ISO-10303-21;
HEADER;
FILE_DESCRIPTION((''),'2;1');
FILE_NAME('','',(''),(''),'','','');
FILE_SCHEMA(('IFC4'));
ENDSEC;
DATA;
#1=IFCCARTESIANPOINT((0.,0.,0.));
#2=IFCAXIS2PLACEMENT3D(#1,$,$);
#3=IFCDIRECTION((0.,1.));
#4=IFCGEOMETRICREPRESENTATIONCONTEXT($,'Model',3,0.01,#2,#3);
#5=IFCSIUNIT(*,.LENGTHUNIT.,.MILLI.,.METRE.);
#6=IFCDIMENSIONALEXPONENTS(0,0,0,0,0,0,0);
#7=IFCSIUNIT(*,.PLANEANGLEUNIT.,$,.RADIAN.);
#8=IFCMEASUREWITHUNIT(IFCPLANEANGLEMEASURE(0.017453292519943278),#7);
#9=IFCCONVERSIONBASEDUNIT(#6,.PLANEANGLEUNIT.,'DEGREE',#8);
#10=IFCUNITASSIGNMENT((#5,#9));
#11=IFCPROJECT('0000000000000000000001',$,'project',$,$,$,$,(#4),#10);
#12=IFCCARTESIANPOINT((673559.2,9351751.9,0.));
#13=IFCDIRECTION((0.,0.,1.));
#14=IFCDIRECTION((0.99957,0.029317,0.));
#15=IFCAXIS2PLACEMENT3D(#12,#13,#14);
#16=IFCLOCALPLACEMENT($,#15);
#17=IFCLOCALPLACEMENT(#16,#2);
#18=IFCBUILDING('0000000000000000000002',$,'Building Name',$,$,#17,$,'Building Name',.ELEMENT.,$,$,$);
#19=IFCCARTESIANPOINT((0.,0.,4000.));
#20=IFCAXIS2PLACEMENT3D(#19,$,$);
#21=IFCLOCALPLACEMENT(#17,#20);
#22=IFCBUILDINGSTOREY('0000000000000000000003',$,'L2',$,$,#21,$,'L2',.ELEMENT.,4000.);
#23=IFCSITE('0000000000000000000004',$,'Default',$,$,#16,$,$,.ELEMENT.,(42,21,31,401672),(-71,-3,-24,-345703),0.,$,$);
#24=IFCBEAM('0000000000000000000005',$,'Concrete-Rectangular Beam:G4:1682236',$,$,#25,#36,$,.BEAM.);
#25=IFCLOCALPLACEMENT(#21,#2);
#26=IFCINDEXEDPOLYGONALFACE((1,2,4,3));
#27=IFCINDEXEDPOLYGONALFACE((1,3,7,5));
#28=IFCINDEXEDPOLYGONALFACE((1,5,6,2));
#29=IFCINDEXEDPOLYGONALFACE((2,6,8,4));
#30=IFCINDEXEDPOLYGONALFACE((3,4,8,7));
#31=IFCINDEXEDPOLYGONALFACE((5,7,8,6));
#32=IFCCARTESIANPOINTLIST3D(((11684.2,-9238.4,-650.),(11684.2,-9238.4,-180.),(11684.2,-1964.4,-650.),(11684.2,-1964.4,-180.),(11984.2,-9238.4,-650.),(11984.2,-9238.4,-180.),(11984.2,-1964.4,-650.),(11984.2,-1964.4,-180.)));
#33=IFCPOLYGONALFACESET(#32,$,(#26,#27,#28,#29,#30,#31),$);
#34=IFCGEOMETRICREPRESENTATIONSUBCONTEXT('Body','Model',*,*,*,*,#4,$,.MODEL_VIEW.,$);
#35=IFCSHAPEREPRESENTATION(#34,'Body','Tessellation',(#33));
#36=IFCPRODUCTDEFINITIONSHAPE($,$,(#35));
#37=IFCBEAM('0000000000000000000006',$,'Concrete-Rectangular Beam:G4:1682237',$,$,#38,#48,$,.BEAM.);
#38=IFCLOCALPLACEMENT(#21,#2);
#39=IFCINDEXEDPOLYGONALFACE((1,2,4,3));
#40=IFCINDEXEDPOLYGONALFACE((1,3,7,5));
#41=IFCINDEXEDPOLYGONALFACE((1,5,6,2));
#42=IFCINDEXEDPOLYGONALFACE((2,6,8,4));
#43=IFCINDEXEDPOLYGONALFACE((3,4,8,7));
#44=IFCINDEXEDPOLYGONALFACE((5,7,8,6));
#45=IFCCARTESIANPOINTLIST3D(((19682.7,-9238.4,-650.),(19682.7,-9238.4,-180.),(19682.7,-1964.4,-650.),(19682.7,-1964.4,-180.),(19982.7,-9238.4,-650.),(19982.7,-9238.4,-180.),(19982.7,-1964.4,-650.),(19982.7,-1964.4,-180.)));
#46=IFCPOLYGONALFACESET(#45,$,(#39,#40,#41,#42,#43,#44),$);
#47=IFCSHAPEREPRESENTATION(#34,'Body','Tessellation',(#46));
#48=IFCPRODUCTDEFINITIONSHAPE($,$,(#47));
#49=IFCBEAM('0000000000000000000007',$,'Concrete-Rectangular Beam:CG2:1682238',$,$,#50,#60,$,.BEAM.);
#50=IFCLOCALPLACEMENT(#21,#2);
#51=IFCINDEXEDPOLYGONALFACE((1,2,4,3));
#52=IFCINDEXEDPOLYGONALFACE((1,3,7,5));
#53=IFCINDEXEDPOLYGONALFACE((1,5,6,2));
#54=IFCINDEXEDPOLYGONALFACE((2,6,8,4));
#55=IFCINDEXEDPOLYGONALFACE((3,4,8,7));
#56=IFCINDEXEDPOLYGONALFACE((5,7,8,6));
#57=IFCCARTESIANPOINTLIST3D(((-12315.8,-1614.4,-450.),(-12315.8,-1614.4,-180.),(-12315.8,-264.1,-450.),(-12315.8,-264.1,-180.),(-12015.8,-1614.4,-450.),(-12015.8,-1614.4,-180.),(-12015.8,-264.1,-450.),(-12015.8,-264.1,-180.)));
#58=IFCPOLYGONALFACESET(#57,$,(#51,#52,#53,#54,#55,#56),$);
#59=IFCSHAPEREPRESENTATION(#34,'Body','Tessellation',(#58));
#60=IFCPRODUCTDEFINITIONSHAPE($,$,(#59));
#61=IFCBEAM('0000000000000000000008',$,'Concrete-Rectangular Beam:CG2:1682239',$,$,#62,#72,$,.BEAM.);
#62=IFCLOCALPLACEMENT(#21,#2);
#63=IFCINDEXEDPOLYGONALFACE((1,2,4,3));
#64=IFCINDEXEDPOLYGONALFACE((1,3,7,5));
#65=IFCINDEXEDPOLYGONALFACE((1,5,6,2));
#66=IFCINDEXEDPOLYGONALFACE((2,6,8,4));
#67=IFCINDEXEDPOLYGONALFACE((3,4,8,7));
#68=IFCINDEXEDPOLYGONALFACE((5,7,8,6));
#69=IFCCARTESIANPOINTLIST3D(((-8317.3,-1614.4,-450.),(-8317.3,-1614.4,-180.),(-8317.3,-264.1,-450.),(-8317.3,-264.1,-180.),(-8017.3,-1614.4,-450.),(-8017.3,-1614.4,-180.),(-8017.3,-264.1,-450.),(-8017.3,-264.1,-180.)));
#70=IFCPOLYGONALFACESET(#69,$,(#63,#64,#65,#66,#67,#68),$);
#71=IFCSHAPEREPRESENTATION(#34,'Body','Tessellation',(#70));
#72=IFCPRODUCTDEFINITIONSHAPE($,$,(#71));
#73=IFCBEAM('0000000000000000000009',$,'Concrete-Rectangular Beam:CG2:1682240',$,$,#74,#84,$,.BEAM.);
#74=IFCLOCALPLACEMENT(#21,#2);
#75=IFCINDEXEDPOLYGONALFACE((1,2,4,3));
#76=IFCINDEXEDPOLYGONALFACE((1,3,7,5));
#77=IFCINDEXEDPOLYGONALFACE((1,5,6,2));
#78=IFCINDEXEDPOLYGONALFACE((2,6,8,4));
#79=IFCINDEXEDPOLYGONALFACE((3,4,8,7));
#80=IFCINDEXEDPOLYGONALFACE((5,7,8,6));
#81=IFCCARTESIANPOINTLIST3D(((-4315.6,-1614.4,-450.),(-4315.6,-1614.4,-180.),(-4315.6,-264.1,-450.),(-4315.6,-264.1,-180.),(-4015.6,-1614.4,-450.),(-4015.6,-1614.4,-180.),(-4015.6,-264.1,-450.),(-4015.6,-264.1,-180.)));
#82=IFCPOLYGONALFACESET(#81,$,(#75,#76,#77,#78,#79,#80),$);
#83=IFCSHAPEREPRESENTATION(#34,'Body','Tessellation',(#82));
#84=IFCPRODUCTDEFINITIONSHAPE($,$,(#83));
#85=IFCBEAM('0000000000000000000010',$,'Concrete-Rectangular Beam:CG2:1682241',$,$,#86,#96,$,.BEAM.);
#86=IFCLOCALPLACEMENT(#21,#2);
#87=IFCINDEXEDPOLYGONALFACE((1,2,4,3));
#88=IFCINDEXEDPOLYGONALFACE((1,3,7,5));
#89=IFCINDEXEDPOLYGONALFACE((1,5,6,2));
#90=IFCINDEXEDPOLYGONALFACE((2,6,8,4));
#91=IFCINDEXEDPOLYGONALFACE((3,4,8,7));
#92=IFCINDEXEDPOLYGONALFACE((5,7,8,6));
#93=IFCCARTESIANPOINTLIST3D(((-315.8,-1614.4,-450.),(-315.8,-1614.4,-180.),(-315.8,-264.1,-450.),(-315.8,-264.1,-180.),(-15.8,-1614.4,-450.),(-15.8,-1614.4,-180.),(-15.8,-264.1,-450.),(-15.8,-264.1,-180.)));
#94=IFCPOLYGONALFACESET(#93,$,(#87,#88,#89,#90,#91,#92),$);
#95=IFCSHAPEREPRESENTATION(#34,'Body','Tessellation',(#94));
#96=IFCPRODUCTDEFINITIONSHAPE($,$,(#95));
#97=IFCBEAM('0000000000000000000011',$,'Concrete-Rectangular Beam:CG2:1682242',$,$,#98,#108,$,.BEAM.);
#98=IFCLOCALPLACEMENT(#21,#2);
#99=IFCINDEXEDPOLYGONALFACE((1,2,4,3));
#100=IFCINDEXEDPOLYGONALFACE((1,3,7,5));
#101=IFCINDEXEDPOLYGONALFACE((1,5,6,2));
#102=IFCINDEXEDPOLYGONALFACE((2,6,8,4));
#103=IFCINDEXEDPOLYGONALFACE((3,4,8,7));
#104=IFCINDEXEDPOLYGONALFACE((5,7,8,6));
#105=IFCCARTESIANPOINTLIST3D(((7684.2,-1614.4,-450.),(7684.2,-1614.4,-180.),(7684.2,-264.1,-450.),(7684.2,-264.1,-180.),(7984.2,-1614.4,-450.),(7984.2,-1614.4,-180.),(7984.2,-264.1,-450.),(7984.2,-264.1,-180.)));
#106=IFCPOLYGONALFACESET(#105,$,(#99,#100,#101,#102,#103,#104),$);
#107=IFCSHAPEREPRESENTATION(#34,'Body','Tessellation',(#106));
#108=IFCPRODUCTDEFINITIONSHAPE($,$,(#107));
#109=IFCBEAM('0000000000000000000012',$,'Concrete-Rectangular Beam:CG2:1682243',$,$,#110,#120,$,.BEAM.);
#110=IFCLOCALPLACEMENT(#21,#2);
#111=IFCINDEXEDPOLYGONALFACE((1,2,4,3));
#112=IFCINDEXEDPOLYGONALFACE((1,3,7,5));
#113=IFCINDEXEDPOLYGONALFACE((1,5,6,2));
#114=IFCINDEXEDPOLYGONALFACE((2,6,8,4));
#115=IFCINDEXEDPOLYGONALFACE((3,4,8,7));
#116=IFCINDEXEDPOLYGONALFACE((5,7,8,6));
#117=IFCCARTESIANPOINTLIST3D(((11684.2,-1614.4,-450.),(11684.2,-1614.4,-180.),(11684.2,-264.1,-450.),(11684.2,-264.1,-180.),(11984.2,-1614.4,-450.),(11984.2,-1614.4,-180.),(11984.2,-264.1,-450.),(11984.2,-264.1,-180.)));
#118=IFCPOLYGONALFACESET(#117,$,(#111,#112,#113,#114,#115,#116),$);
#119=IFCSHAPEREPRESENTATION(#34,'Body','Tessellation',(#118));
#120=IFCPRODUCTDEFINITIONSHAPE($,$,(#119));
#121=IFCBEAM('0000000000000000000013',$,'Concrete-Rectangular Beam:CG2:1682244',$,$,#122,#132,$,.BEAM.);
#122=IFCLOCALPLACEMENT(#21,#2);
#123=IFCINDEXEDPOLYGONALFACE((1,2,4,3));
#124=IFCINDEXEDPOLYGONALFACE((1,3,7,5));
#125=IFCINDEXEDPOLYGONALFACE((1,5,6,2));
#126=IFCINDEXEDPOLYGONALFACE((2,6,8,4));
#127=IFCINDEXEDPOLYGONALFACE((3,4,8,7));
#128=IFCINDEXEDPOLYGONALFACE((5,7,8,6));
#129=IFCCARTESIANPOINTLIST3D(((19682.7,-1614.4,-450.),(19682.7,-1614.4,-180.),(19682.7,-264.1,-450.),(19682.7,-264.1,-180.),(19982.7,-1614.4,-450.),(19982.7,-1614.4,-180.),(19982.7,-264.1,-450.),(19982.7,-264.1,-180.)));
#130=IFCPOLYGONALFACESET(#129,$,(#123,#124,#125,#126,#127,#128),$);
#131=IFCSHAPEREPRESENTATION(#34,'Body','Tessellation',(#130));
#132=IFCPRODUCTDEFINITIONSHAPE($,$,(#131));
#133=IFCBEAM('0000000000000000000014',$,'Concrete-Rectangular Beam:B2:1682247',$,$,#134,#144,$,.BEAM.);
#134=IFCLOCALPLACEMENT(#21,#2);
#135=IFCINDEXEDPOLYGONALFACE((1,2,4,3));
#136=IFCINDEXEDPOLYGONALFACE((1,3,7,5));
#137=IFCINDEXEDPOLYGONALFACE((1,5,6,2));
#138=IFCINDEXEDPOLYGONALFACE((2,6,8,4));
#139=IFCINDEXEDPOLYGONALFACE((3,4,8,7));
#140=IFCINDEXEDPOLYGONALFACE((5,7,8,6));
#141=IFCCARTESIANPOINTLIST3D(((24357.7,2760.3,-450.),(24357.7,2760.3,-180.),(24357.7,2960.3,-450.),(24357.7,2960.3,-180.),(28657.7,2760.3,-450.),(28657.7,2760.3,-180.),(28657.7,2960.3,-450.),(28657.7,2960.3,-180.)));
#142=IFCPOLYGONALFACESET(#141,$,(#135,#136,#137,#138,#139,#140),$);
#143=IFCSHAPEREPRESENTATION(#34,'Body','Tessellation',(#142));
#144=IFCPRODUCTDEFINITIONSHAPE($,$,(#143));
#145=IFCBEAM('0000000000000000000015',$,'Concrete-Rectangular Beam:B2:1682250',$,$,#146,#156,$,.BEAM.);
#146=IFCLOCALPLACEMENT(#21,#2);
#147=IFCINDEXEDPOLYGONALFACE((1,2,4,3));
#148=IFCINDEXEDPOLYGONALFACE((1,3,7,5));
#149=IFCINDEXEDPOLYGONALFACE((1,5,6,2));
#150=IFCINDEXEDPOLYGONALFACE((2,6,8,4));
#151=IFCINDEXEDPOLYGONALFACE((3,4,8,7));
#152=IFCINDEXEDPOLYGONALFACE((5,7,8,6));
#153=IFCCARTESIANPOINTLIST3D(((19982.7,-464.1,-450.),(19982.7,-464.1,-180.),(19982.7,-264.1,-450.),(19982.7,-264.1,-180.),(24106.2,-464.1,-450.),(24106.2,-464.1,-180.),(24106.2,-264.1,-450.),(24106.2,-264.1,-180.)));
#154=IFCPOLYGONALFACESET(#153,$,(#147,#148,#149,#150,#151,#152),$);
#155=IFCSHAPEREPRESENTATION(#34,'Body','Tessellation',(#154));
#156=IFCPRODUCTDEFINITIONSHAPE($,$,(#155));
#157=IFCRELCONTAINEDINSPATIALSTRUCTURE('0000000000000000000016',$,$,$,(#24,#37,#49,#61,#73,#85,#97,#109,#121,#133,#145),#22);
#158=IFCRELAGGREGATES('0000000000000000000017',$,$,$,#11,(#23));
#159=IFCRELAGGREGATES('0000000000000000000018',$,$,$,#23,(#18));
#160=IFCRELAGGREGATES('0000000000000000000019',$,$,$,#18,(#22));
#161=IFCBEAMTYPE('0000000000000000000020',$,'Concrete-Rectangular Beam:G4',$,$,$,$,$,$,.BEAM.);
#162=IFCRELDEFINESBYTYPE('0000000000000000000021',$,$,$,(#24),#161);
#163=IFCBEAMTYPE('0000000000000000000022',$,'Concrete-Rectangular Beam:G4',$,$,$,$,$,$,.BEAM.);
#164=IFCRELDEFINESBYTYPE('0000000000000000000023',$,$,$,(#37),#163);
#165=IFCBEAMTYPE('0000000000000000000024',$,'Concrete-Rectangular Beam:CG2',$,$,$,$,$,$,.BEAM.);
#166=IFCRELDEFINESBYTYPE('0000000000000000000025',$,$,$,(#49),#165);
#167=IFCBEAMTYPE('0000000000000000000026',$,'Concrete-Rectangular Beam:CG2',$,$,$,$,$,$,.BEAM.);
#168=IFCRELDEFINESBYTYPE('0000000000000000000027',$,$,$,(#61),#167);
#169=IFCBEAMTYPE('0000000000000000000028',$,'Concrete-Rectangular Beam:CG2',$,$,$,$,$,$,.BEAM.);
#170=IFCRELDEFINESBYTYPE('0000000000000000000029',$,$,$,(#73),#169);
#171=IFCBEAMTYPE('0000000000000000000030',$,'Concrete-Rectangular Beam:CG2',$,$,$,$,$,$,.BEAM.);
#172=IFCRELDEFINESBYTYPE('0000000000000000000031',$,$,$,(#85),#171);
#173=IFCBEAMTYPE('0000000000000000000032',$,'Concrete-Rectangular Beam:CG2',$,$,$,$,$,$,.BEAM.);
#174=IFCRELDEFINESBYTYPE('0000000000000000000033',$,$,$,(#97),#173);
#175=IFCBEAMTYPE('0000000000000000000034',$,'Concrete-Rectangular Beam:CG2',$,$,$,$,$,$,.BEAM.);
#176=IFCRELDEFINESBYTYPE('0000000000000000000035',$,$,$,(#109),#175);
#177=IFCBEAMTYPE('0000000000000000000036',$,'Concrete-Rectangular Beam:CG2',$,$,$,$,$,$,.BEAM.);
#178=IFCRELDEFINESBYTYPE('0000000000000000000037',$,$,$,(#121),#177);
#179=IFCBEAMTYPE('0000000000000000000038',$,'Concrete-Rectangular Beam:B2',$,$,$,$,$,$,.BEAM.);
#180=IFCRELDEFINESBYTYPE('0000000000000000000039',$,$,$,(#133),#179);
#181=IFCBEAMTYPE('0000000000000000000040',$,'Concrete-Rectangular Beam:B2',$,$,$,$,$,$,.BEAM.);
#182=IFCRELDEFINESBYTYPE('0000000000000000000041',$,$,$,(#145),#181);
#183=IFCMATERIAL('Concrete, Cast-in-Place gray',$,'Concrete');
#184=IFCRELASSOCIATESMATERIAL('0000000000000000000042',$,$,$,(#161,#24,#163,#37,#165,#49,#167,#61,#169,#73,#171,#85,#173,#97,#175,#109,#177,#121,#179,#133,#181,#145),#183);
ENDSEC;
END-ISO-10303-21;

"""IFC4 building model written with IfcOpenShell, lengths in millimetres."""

from ifc_helpers import new_model, entity, si_unit, converted_unit, direction, frame, origin, place, context, subcontext, project, spatial, indexed_curve, outline, extrude, source, transform, mapped, material, type_object, type_shapes, element, save


model = new_model("IFC4")

# Units and contexts
model_context = context("Model", 3, precision=0.01, world=origin(), true_north=direction((0.0, 1.0)))
body_context = subcontext(model_context, "Body", "Model", "MODEL_VIEW")
ifc_project = project(units=[si_unit("LENGTHUNIT", "METRE", prefix="MILLI"), converted_unit("PLANEANGLEUNIT", "DEGREE", entity("IfcPlaneAngleMeasure", 0.017453292519943278), si_unit("PLANEANGLEUNIT", "RADIAN"), dimensions=[0, 0, 0, 0, 0, 0, 0])], contexts=[model_context])

# Site, building, storey
site_placement = place(None, frame((673559.2, 9351751.9, 0.0), z_axis=(0.0, 0.0, 1.0), x_axis=(0.99957, 0.029317, 0.0)))
site = spatial("IfcSite", under=ifc_project, at=site_placement, Name="Default", CompositionType="ELEMENT", RefLatitude=(42, 21, 31, 401672), RefLongitude=(-71, -3, -24, -345703), RefElevation=0.0)
building_placement = place(site_placement, origin())
building = spatial("IfcBuilding", under=site, at=building_placement, Name="Building Name", LongName="Building Name", CompositionType="ELEMENT")
storey_placement = place(building_placement, frame((0.0, 0.0, 4000.0)))
storey = spatial("IfcBuildingStorey", under=building, at=storey_placement, Name="L2", LongName="L2", CompositionType="ELEMENT", Elevation=4000.0)

# Beams
ifc_material = material(Name="Concrete, Cast-in-Place gray", Category="Concrete")
beam_type_1 = type_object("IfcBeamType", Name="Concrete-Rectangular Beam:G4", PredefinedType="BEAM", material=ifc_material)
shared_shape_1 = source(origin(), body_context, "Body", "SweptSolid", [
    extrude(outline(indexed_curve([(-150.0, -235.0), (150.0, -235.0), (150.0, 235.0), (-150.0, 235.0), (-150.0, -235.0)], self_intersect=False)), frame((11834.2, -9238.4, 3585.0), z_axis=(0.0, 1.0, 0.0), x_axis=(-1.0, 0.0, 0.0)), (0.0, 0.0, 1.0), 7273.9),
])
type_shapes(beam_type_1, [shared_shape_1])
beam_1_placement = place(storey_placement, frame((0.0, 0.0, -4000.0)))
element("IfcBeam", 1, at=beam_1_placement, inside=storey, type_object=beam_type_1, material=ifc_material, Name="Concrete-Rectangular Beam:G4:1682236", PredefinedType="BEAM", context=body_context, shape_type="MappedRepresentation", body=[
    mapped(shared_shape_1, transform((0.0, 0.0, 0.0), scale=1.0)),
])
beam_type_2 = type_object("IfcBeamType", Name="Concrete-Rectangular Beam:G4", PredefinedType="BEAM", material=ifc_material)
shared_shape_2 = source(origin(), body_context, "Body", "SweptSolid", [
    extrude(outline(indexed_curve([(-150.0, -235.0), (150.0, -235.0), (150.0, 235.0), (-150.0, 235.0), (-150.0, -235.0)], self_intersect=False)), frame((19832.7, -9238.4, 3585.0), z_axis=(0.0, 1.0, 0.0), x_axis=(-1.0, 0.0, 0.0)), (0.0, 0.0, 1.0), 7273.9),
])
type_shapes(beam_type_2, [shared_shape_2])
beam_2_placement = place(storey_placement, frame((0.0, 0.0, -4000.0)))
element("IfcBeam", 2, at=beam_2_placement, inside=storey, type_object=beam_type_2, material=ifc_material, Name="Concrete-Rectangular Beam:G4:1682237", PredefinedType="BEAM", context=body_context, shape_type="MappedRepresentation", body=[
    mapped(shared_shape_2, transform((0.0, 0.0, 0.0), scale=1.0)),
])
beam_type_3 = type_object("IfcBeamType", Name="Concrete-Rectangular Beam:CG2", PredefinedType="BEAM", material=ifc_material)
shared_shape_3 = source(origin(), body_context, "Body", "SweptSolid", [
    extrude(outline(indexed_curve([(-150.0, -135.0), (150.0, -135.0), (150.0, 135.0), (-150.0, 135.0), (-150.0, -135.0)], self_intersect=False)), frame((-12165.8, -1614.4, 3685.0), z_axis=(0.0, 1.0, 0.0), x_axis=(-1.0, 0.0, 0.0)), (0.0, 0.0, 1.0), 1350.4),
])
type_shapes(beam_type_3, [shared_shape_3])
beam_3_placement = place(storey_placement, frame((0.0, 0.0, -4000.0)))
element("IfcBeam", 3, at=beam_3_placement, inside=storey, type_object=beam_type_3, material=ifc_material, Name="Concrete-Rectangular Beam:CG2:1682238", PredefinedType="BEAM", context=body_context, shape_type="MappedRepresentation", body=[
    mapped(shared_shape_3, transform((0.0, 0.0, 0.0), scale=1.0)),
])
beam_type_4 = type_object("IfcBeamType", Name="Concrete-Rectangular Beam:CG2", PredefinedType="BEAM", material=ifc_material)
shared_shape_4 = source(origin(), body_context, "Body", "SweptSolid", [
    extrude(outline(indexed_curve([(-150.0, -135.0), (150.0, -135.0), (150.0, 135.0), (-150.0, 135.0), (-150.0, -135.0)], self_intersect=False)), frame((-8167.3, -1614.4, 3685.0), z_axis=(0.0, 1.0, 0.0), x_axis=(-1.0, 0.0, 0.0)), (0.0, 0.0, 1.0), 1350.4),
])
type_shapes(beam_type_4, [shared_shape_4])
beam_4_placement = place(storey_placement, frame((0.0, 0.0, -4000.0)))
element("IfcBeam", 4, at=beam_4_placement, inside=storey, type_object=beam_type_4, material=ifc_material, Name="Concrete-Rectangular Beam:CG2:1682239", PredefinedType="BEAM", context=body_context, shape_type="MappedRepresentation", body=[
    mapped(shared_shape_4, transform((0.0, 0.0, 0.0), scale=1.0)),
])
beam_type_5 = type_object("IfcBeamType", Name="Concrete-Rectangular Beam:CG2", PredefinedType="BEAM", material=ifc_material)
shared_shape_5 = source(origin(), body_context, "Body", "SweptSolid", [
    extrude(outline(indexed_curve([(-150.0, -135.0), (150.0, -135.0), (150.0, 135.0), (-150.0, 135.0), (-150.0, -135.0)], self_intersect=False)), frame((-4165.6, -1614.4, 3685.0), z_axis=(0.0, 1.0, 0.0), x_axis=(-1.0, 0.0, 0.0)), (0.0, 0.0, 1.0), 1350.4),
])
type_shapes(beam_type_5, [shared_shape_5])
beam_5_placement = place(storey_placement, frame((0.0, 0.0, -4000.0)))
element("IfcBeam", 5, at=beam_5_placement, inside=storey, type_object=beam_type_5, material=ifc_material, Name="Concrete-Rectangular Beam:CG2:1682240", PredefinedType="BEAM", context=body_context, shape_type="MappedRepresentation", body=[
    mapped(shared_shape_5, transform((0.0, 0.0, 0.0), scale=1.0)),
])
beam_type_6 = type_object("IfcBeamType", Name="Concrete-Rectangular Beam:CG2", PredefinedType="BEAM", material=ifc_material)
shared_shape_6 = source(origin(), body_context, "Body", "SweptSolid", [
    extrude(outline(indexed_curve([(-150.0, -135.0), (150.0, -135.0), (150.0, 135.0), (-150.0, 135.0), (-150.0, -135.0)], self_intersect=False)), frame((-165.8, -1614.4, 3685.0), z_axis=(0.0, 1.0, 0.0), x_axis=(-1.0, 0.0, 0.0)), (0.0, 0.0, 1.0), 1350.4),
])
type_shapes(beam_type_6, [shared_shape_6])
beam_6_placement = place(storey_placement, frame((0.0, 0.0, -4000.0)))
element("IfcBeam", 6, at=beam_6_placement, inside=storey, type_object=beam_type_6, material=ifc_material, Name="Concrete-Rectangular Beam:CG2:1682241", PredefinedType="BEAM", context=body_context, shape_type="MappedRepresentation", body=[
    mapped(shared_shape_6, transform((0.0, 0.0, 0.0), scale=1.0)),
])
beam_type_7 = type_object("IfcBeamType", Name="Concrete-Rectangular Beam:CG2", PredefinedType="BEAM", material=ifc_material)
shared_shape_7 = source(origin(), body_context, "Body", "SweptSolid", [
    extrude(outline(indexed_curve([(-150.0, -135.0), (150.0, -135.0), (150.0, 135.0), (-150.0, 135.0), (-150.0, -135.0)], self_intersect=False)), frame((7834.2, -1614.4, 3685.0), z_axis=(0.0, 1.0, 0.0), x_axis=(-1.0, 0.0, 0.0)), (0.0, 0.0, 1.0), 1350.4),
])
type_shapes(beam_type_7, [shared_shape_7])
beam_7_placement = place(storey_placement, frame((0.0, 0.0, -4000.0)))
element("IfcBeam", 7, at=beam_7_placement, inside=storey, type_object=beam_type_7, material=ifc_material, Name="Concrete-Rectangular Beam:CG2:1682242", PredefinedType="BEAM", context=body_context, shape_type="MappedRepresentation", body=[
    mapped(shared_shape_7, transform((0.0, 0.0, 0.0), scale=1.0)),
])
beam_type_8 = type_object("IfcBeamType", Name="Concrete-Rectangular Beam:CG2", PredefinedType="BEAM", material=ifc_material)
shared_shape_8 = source(origin(), body_context, "Body", "SweptSolid", [
    extrude(outline(indexed_curve([(-150.0, -135.0), (150.0, -135.0), (150.0, 135.0), (-150.0, 135.0), (-150.0, -135.0)], self_intersect=False)), frame((11834.2, -1614.4, 3685.0), z_axis=(0.0, 1.0, 0.0), x_axis=(-1.0, 0.0, 0.0)), (0.0, 0.0, 1.0), 1350.4),
])
type_shapes(beam_type_8, [shared_shape_8])
beam_8_placement = place(storey_placement, frame((0.0, 0.0, -4000.0)))
element("IfcBeam", 8, at=beam_8_placement, inside=storey, type_object=beam_type_8, material=ifc_material, Name="Concrete-Rectangular Beam:CG2:1682243", PredefinedType="BEAM", context=body_context, shape_type="MappedRepresentation", body=[
    mapped(shared_shape_8, transform((0.0, 0.0, 0.0), scale=1.0)),
])
beam_type_9 = type_object("IfcBeamType", Name="Concrete-Rectangular Beam:CG2", PredefinedType="BEAM", material=ifc_material)
shared_shape_9 = source(origin(), body_context, "Body", "SweptSolid", [
    extrude(outline(indexed_curve([(-150.0, -135.0), (150.0, -135.0), (150.0, 135.0), (-150.0, 135.0), (-150.0, -135.0)], self_intersect=False)), frame((19832.7, -1614.4, 3685.0), z_axis=(0.0, 1.0, 0.0), x_axis=(-1.0, 0.0, 0.0)), (0.0, 0.0, 1.0), 1350.4),
])
type_shapes(beam_type_9, [shared_shape_9])
beam_9_placement = place(storey_placement, frame((0.0, 0.0, -4000.0)))
element("IfcBeam", 9, at=beam_9_placement, inside=storey, type_object=beam_type_9, material=ifc_material, Name="Concrete-Rectangular Beam:CG2:1682244", PredefinedType="BEAM", context=body_context, shape_type="MappedRepresentation", body=[
    mapped(shared_shape_9, transform((0.0, 0.0, 0.0), scale=1.0)),
])
beam_type_10 = type_object("IfcBeamType", Name="Concrete-Rectangular Beam:B2", PredefinedType="BEAM", material=ifc_material)
shared_shape_10 = source(origin(), body_context, "Body", "SweptSolid", [
    extrude(outline(indexed_curve([(-135.0, -100.0), (135.0, -100.0), (135.0, 100.0), (-135.0, 100.0), (-135.0, -100.0)], self_intersect=False)), frame((24357.7, 2860.3, 3685.0), z_axis=(1.0, 0.0, 0.0), x_axis=(0.0, 0.0, -1.0)), (0.0, 0.0, 1.0), 4300.0),
])
type_shapes(beam_type_10, [shared_shape_10])
beam_10_placement = place(storey_placement, frame((0.0, 0.0, -4000.0)))
element("IfcBeam", 10, at=beam_10_placement, inside=storey, type_object=beam_type_10, material=ifc_material, Name="Concrete-Rectangular Beam:B2:1682247", PredefinedType="BEAM", context=body_context, shape_type="MappedRepresentation", body=[
    mapped(shared_shape_10, transform((0.0, 0.0, 0.0), scale=1.0)),
])
beam_type_11 = type_object("IfcBeamType", Name="Concrete-Rectangular Beam:B2", PredefinedType="BEAM", material=ifc_material)
shared_shape_11 = source(origin(), body_context, "Body", "SweptSolid", [
    extrude(outline(indexed_curve([(-135.0, -100.0), (135.0, -100.0), (135.0, 100.0), (-135.0, 100.0), (-135.0, -100.0)], self_intersect=False)), frame((24106.2, -364.1, 3685.0), z_axis=(-1.0, 0.0, 0.0), x_axis=(0.0, 0.0, -1.0)), (0.0, 0.0, 1.0), 4123.5),
])
type_shapes(beam_type_11, [shared_shape_11])
beam_11_placement = place(storey_placement, frame((0.0, 0.0, -4000.0)))
element("IfcBeam", 11, at=beam_11_placement, inside=storey, type_object=beam_type_11, material=ifc_material, Name="Concrete-Rectangular Beam:B2:1682250", PredefinedType="BEAM", context=body_context, shape_type="MappedRepresentation", body=[
    mapped(shared_shape_11, transform((0.0, 0.0, 0.0), scale=1.0)),
])

save(model, "model.ifc")
